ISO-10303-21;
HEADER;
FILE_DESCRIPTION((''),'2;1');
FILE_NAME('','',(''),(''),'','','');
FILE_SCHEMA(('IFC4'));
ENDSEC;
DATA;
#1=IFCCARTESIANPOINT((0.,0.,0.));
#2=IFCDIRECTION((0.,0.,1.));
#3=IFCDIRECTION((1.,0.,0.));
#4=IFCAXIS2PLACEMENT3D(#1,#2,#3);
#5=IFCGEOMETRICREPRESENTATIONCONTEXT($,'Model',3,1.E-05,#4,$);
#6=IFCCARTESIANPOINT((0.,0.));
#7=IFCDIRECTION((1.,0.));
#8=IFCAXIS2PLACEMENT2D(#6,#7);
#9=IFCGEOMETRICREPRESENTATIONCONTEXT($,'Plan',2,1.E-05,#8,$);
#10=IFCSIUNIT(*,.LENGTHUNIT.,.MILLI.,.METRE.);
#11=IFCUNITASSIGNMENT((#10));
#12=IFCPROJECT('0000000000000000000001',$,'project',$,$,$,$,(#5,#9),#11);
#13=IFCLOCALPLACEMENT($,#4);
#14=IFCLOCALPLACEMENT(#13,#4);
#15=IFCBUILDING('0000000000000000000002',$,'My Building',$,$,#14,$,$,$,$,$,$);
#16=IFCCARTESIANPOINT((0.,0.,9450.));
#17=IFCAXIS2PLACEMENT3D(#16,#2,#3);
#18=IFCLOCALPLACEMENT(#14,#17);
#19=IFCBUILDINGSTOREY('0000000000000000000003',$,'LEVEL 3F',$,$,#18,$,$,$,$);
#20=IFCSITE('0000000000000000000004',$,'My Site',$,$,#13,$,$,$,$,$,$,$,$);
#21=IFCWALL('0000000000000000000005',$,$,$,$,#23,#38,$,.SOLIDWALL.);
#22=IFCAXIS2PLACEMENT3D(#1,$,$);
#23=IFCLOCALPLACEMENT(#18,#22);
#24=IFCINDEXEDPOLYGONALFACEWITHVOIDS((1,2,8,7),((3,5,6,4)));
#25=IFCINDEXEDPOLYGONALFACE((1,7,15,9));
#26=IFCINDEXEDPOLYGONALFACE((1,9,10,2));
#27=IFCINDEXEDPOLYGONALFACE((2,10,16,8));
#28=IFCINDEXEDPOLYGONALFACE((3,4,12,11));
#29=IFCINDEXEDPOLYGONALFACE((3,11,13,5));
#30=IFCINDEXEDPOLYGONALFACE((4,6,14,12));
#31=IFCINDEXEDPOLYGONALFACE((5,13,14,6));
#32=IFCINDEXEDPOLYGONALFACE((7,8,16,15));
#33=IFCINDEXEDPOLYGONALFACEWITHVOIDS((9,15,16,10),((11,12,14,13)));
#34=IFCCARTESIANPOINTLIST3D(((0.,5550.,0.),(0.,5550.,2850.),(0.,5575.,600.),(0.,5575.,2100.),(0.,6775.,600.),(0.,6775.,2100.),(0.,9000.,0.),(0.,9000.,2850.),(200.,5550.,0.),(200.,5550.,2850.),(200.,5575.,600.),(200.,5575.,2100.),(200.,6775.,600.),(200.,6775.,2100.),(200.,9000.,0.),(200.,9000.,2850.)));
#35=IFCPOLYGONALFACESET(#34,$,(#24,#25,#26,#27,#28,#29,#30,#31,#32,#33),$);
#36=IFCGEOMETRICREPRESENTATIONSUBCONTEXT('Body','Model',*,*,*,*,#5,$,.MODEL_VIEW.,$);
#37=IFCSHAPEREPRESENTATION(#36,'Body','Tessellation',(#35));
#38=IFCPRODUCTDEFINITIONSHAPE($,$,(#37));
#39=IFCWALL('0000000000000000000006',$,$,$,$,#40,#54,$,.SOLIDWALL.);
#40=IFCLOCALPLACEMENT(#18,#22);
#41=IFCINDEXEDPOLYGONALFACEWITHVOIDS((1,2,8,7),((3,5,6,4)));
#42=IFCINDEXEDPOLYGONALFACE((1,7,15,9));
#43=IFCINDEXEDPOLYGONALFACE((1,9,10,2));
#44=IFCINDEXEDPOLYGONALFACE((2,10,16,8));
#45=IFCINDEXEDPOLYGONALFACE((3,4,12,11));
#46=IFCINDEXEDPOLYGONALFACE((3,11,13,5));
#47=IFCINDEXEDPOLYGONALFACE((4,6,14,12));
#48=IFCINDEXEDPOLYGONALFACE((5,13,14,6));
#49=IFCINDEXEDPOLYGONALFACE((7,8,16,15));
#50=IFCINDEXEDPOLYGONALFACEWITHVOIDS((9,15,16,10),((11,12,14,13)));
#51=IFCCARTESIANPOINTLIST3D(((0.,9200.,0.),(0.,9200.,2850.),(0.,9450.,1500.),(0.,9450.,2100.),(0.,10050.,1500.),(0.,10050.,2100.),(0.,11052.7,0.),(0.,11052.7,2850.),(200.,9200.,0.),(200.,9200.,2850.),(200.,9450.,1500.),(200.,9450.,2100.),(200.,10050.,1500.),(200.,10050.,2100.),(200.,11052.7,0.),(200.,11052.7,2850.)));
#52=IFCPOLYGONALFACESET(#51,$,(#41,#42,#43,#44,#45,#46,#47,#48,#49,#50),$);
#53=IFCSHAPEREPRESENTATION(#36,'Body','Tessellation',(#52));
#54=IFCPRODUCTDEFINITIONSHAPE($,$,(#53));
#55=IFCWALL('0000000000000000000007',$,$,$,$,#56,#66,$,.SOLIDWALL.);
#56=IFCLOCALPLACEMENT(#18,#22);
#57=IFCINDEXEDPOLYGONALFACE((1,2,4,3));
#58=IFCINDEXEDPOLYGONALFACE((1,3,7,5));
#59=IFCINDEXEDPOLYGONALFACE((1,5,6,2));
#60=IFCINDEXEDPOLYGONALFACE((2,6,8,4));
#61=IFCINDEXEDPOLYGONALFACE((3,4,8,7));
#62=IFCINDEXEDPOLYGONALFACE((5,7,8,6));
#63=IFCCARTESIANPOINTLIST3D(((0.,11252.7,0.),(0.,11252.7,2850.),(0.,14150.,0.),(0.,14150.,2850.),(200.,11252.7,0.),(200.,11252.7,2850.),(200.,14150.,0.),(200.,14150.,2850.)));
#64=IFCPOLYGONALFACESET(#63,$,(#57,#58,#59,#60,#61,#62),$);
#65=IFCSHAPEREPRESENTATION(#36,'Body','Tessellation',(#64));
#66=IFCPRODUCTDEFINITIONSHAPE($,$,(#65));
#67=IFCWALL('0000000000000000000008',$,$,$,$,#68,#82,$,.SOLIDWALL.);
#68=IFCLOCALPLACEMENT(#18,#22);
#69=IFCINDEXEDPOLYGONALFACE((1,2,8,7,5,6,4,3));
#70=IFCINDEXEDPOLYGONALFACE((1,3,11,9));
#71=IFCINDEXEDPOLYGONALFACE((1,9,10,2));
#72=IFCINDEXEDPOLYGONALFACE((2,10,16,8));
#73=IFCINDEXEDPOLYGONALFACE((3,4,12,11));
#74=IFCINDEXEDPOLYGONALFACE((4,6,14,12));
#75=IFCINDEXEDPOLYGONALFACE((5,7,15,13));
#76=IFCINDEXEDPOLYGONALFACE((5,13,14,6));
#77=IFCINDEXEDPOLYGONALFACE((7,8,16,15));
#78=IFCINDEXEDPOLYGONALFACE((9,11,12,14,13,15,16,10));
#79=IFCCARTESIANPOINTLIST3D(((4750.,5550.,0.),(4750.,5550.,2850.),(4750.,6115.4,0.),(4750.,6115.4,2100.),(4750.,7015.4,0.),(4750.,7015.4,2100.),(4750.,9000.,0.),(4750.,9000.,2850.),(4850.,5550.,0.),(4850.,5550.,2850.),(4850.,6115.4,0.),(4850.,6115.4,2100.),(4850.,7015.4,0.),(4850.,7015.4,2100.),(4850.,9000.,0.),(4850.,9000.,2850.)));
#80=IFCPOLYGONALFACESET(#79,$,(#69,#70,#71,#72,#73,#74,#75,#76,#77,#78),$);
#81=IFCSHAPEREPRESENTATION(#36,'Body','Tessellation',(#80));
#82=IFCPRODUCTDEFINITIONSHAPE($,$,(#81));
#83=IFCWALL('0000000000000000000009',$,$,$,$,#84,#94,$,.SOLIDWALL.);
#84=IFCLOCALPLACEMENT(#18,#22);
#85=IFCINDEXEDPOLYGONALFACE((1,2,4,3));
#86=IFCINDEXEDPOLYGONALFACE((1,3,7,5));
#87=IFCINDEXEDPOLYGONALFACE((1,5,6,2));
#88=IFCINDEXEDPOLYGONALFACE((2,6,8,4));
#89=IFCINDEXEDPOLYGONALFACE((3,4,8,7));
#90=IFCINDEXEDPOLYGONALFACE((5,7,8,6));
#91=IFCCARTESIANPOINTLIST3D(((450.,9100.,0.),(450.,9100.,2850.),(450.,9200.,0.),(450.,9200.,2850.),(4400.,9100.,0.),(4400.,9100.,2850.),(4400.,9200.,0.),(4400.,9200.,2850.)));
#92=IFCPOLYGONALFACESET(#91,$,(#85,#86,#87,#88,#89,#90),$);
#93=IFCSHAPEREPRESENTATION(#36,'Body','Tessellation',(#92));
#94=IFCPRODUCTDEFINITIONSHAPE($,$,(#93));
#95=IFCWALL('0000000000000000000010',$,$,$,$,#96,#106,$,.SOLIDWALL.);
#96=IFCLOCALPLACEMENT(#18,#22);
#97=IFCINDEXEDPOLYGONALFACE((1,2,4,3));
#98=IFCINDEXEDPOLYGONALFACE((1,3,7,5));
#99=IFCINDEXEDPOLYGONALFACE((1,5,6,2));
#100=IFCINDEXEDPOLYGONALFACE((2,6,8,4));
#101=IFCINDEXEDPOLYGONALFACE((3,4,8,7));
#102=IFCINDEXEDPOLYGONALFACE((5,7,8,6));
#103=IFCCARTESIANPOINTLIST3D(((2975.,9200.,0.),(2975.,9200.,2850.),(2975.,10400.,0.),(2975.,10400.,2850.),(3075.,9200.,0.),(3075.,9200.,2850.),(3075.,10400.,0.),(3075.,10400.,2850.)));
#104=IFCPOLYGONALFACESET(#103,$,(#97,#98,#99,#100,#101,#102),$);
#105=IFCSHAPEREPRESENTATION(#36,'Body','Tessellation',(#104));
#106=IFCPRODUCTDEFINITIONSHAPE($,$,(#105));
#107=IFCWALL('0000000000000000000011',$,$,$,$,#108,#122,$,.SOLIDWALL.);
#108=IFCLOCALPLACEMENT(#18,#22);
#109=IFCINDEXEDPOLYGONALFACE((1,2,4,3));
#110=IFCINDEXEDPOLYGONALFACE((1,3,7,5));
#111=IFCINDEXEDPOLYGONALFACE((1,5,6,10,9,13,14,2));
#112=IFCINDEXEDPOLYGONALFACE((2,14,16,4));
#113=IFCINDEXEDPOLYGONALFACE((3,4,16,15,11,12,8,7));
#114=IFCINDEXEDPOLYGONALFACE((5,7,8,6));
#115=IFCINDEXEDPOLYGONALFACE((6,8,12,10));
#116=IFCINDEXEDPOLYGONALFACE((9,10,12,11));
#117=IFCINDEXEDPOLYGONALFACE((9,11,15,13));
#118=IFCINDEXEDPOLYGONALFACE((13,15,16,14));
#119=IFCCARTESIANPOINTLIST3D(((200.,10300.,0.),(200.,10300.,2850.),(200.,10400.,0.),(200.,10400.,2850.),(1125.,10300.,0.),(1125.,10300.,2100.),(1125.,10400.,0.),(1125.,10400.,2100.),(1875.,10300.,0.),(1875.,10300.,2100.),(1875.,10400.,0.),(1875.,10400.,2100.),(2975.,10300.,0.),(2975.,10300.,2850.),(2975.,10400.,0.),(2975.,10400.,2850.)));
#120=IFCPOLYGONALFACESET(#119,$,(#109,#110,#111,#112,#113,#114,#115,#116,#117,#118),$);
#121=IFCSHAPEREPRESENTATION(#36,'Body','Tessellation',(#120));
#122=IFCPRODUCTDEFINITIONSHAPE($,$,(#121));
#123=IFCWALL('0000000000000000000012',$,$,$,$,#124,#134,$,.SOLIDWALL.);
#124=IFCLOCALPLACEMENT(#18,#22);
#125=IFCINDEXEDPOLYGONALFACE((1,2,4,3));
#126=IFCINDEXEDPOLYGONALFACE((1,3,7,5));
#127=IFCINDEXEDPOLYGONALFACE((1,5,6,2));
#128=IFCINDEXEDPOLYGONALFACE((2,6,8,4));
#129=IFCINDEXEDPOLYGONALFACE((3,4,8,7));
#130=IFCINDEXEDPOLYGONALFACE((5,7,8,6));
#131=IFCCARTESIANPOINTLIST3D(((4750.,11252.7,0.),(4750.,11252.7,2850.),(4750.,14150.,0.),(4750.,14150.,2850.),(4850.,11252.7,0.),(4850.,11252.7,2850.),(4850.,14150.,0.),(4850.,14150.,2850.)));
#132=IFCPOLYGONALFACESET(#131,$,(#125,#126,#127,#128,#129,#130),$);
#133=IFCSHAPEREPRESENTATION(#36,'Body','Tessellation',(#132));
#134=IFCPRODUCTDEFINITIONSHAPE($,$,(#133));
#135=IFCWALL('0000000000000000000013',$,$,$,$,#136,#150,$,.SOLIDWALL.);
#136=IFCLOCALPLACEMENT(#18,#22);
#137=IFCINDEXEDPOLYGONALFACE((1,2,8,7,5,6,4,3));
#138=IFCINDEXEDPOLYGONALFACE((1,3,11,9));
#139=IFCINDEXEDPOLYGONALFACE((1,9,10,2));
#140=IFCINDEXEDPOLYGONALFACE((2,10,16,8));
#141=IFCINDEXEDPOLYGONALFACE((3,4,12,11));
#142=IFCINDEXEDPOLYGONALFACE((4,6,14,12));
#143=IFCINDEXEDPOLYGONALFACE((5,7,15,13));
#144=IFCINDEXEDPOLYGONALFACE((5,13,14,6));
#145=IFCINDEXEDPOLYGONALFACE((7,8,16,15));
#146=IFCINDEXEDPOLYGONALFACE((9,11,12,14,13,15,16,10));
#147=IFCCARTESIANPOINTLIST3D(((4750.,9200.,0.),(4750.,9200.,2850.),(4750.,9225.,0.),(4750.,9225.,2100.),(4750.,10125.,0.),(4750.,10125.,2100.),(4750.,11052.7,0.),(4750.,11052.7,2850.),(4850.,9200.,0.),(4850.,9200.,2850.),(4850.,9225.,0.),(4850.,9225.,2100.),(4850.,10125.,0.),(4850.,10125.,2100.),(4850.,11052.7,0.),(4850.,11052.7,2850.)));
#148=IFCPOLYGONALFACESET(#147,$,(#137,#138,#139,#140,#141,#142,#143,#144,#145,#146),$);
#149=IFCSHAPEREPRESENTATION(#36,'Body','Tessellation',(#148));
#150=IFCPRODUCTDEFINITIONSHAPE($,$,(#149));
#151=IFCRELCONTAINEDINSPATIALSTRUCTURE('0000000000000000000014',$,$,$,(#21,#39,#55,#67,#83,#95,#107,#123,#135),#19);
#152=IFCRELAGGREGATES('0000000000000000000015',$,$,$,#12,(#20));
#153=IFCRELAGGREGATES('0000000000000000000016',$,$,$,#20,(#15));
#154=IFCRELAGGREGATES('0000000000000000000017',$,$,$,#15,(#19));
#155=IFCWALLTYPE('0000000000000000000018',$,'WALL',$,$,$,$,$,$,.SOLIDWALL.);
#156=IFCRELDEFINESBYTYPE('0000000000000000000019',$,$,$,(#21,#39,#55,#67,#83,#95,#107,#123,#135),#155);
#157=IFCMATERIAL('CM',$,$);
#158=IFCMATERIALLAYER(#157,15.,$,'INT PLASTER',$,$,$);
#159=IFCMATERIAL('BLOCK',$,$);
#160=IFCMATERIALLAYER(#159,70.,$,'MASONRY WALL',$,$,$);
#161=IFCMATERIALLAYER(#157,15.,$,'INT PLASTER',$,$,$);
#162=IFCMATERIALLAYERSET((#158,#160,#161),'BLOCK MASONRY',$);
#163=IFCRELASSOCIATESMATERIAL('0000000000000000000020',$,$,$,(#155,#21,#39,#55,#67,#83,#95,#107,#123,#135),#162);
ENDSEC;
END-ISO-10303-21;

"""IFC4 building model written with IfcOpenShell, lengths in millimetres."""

from ifc_helpers import new_model, si_unit, frame, origin_with_axes, origin_2d_with_axis, place, context, subcontext, project, spatial, indexed_curve, outline, extrude, material, layer, layer_set, layer_usage, type_object, element, save


model = new_model("IFC4")

# Units and contexts
model_context = context("Model", 3, precision=1e-05, world=origin_with_axes())
plan_context = context("Plan", 2, precision=1e-05, world=origin_2d_with_axis())
body_context = subcontext(model_context, "Body", "Model", "MODEL_VIEW")
ifc_project = project(units=[si_unit("LENGTHUNIT", "METRE", prefix="MILLI")], contexts=[model_context, plan_context])

# Site, building, storey
site_placement = place(None, origin_with_axes())
site = spatial("IfcSite", under=ifc_project, at=site_placement, Name="My Site")
building_placement = place(site_placement, origin_with_axes())
building = spatial("IfcBuilding", under=site, at=building_placement, Name="My Building")
storey_placement = place(building_placement, frame((0.0, 0.0, 9450.0), z_axis=(0.0, 0.0, 1.0), x_axis=(1.0, 0.0, 0.0)))
storey = spatial("IfcBuildingStorey", under=building, at=storey_placement, Name="LEVEL 3F")

# Shared definitions
ifc_material_1 = material(Name="CM")
ifc_layer_1 = layer(ifc_material_1, 15.0, Name="INT PLASTER")
ifc_material_2 = material(Name="BLOCK")
ifc_layer_2 = layer(ifc_material_2, 70.0, Name="MASONRY WALL")
ifc_layer_3 = layer(ifc_material_1, 15.0, Name="INT PLASTER")
ifc_layer_set = layer_set([ifc_layer_1, ifc_layer_2, ifc_layer_3], Name="BLOCK MASONRY")
wall_type = type_object("IfcWallType", Name="WALL", PredefinedType="SOLIDWALL", material=ifc_layer_set)

# Walls, openings
ifc_layer_usage_1 = layer_usage(ifc_layer_set, "AXIS2", "POSITIVE", 0.0)
wall_1_placement = place(storey_placement, frame((200.0, 5550.0, 0.0), z_axis=(0.0, 0.0, 1.0), x_axis=(0.0, 1.0, 0.0)))
wall_1 = element("IfcWall", 1, at=wall_1_placement, inside=storey, type_object=wall_type, material=ifc_layer_usage_1, PredefinedType="SOLIDWALL", context=body_context, shape_type="SweptSolid", body=[
    extrude(outline(indexed_curve([(0.0, 0.0), (0.0, 200.0), (3450.0, 200.0), (3450.0, 0.0), (0.0, 0.0)], self_intersect=False)), origin_with_axes(), (0.0, 0.0, 1.0), 2850.0),
])
opening_1_placement = place(wall_1_placement, frame((25.0, 0.0, 600.0), z_axis=(0.0, 0.0, 1.0), x_axis=(1.0, 0.0, 0.0)))
element("IfcOpeningElement", 2, at=opening_1_placement, cuts=wall_1, PredefinedType="OPENING", context=body_context, shape_type="SweptSolid", body=[
    extrude(outline(indexed_curve([(0.0, 0.0), (0.0, 400.0), (1200.0, 400.0), (1200.0, 0.0), (0.0, 0.0)], self_intersect=False)), frame((0.0, -100.0, 0.0), z_axis=(0.0, 0.0, 1.0), x_axis=(1.0, 0.0, 0.0)), (0.0, 0.0, 1.0), 1500.0),
])
ifc_layer_usage_2 = layer_usage(ifc_layer_set, "AXIS2", "POSITIVE", 0.0)
wall_2_placement = place(storey_placement, frame((200.0, 9200.0, 0.0), z_axis=(0.0, 0.0, 1.0), x_axis=(0.0, 1.0, 0.0)))
wall_2 = element("IfcWall", 3, at=wall_2_placement, inside=storey, type_object=wall_type, material=ifc_layer_usage_2, PredefinedType="SOLIDWALL", context=body_context, shape_type="SweptSolid", body=[
    extrude(outline(indexed_curve([(0.0, 0.0), (0.0, 200.0), (1852.7, 200.0), (1852.7, 0.0), (0.0, 0.0)], self_intersect=False)), origin_with_axes(), (0.0, 0.0, 1.0), 2850.0),
])
opening_2_placement = place(wall_2_placement, frame((250.0, 0.0, 1500.0), z_axis=(0.0, 0.0, 1.0), x_axis=(1.0, 0.0, 0.0)))
element("IfcOpeningElement", 4, at=opening_2_placement, cuts=wall_2, PredefinedType="OPENING", context=body_context, shape_type="SweptSolid", body=[
    extrude(outline(indexed_curve([(0.0, 0.0), (0.0, 400.0), (600.0, 400.0), (600.0, 0.0), (0.0, 0.0)], self_intersect=False)), frame((0.0, -100.0, 0.0), z_axis=(0.0, 0.0, 1.0), x_axis=(1.0, 0.0, 0.0)), (0.0, 0.0, 1.0), 600.0),
])

# Wall
ifc_layer_usage_3 = layer_usage(ifc_layer_set, "AXIS2", "POSITIVE", 0.0)
wall_3_placement = place(storey_placement, frame((200.0, 11252.7, 0.0), z_axis=(0.0, 0.0, 1.0), x_axis=(0.0, 1.0, 0.0)))
element("IfcWall", 5, at=wall_3_placement, inside=storey, type_object=wall_type, material=ifc_layer_usage_3, PredefinedType="SOLIDWALL", context=body_context, shape_type="SweptSolid", body=[
    extrude(outline(indexed_curve([(0.0, 0.0), (0.0, 200.0), (2897.3, 200.0), (2897.3, 0.0), (0.0, 0.0)], self_intersect=False)), origin_with_axes(), (0.0, 0.0, 1.0), 2850.0),
])

# Wall, opening
ifc_layer_usage_4 = layer_usage(ifc_layer_set, "AXIS2", "POSITIVE", 0.0)
wall_4_placement = place(storey_placement, frame((4850.0, 5550.0, 0.0), z_axis=(0.0, 0.0, 1.0), x_axis=(0.0, 1.0, 0.0)))
wall_4 = element("IfcWall", 6, at=wall_4_placement, inside=storey, type_object=wall_type, material=ifc_layer_usage_4, PredefinedType="SOLIDWALL", context=body_context, shape_type="SweptSolid", body=[
    extrude(outline(indexed_curve([(0.0, 0.0), (0.0, 100.0), (3450.0, 100.0), (3450.0, 0.0), (0.0, 0.0)], self_intersect=False)), origin_with_axes(), (0.0, 0.0, 1.0), 2850.0),
])
opening_3_placement = place(wall_4_placement, frame((565.4, 0.0, 0.0), z_axis=(0.0, 0.0, 1.0), x_axis=(1.0, 0.0, 0.0)))
element("IfcOpeningElement", 7, at=opening_3_placement, cuts=wall_4, PredefinedType="OPENING", context=body_context, shape_type="SweptSolid", body=[
    extrude(outline(indexed_curve([(0.0, 0.0), (0.0, 400.0), (900.0, 400.0), (900.0, 0.0), (0.0, 0.0)], self_intersect=False)), frame((0.0, -100.0, 0.0), z_axis=(0.0, 0.0, 1.0), x_axis=(1.0, 0.0, 0.0)), (0.0, 0.0, 1.0), 2100.0),
])

# Walls
ifc_layer_usage_5 = layer_usage(ifc_layer_set, "AXIS2", "POSITIVE", 0.0)
wall_5_placement = place(storey_placement, frame((450.0, 9200.0, 0.0), z_axis=(0.0, 0.0, 1.0), x_axis=(0.0, -1.0, 0.0)))
element("IfcWall", 8, at=wall_5_placement, inside=storey, type_object=wall_type, material=ifc_layer_usage_5, PredefinedType="SOLIDWALL", context=body_context, shape_type="SweptSolid", body=[
    extrude(outline(indexed_curve([(0.0, 0.0), (0.0, 3950.0), (100.0, 3950.0), (100.0, 0.0), (0.0, 0.0)], self_intersect=False)), origin_with_axes(), (0.0, 0.0, 1.0), 2850.0),
])
ifc_layer_usage_6 = layer_usage(ifc_layer_set, "AXIS2", "POSITIVE", 0.0)
wall_6_placement = place(storey_placement, frame((3075.0, 9200.0, 0.0), z_axis=(0.0, 0.0, 1.0), x_axis=(0.0, 1.0, 0.0)))
element("IfcWall", 9, at=wall_6_placement, inside=storey, type_object=wall_type, material=ifc_layer_usage_6, PredefinedType="SOLIDWALL", context=body_context, shape_type="SweptSolid", body=[
    extrude(outline(indexed_curve([(0.0, 0.0), (0.0, 100.0), (1200.0, 100.0), (1200.0, 0.0), (0.0, 0.0)], self_intersect=False)), origin_with_axes(), (0.0, 0.0, 1.0), 2850.0),
])

# Wall, opening
ifc_layer_usage_7 = layer_usage(ifc_layer_set, "AXIS2", "POSITIVE", 0.0)
wall_7_placement = place(storey_placement, frame((200.0, 10400.0, 0.0), z_axis=(0.0, 0.0, 1.0), x_axis=(0.0, -1.0, 0.0)))
wall_7 = element("IfcWall", 10, at=wall_7_placement, inside=storey, type_object=wall_type, material=ifc_layer_usage_7, PredefinedType="SOLIDWALL", context=body_context, shape_type="SweptSolid", body=[
    extrude(outline(indexed_curve([(0.0, 0.0), (0.0, 2775.0), (100.0, 2775.0), (100.0, 0.0), (0.0, 0.0)], self_intersect=False)), origin_with_axes(), (0.0, 0.0, 1.0), 2850.0),
])
opening_4_placement = place(wall_7_placement, frame((0.0, 1675.0, 0.0), z_axis=(0.0, 0.0, 1.0), x_axis=(0.0, -1.0, 0.0)))
element("IfcOpeningElement", 11, at=opening_4_placement, cuts=wall_7, PredefinedType="OPENING", context=body_context, shape_type="SweptSolid", body=[
    extrude(outline(indexed_curve([(0.0, 0.0), (0.0, 400.0), (750.0, 400.0), (750.0, 0.0), (0.0, 0.0)], self_intersect=False)), frame((0.0, -100.0, 0.0), z_axis=(0.0, 0.0, 1.0), x_axis=(1.0, 0.0, 0.0)), (0.0, 0.0, 1.0), 2100.0),
])

# Wall
ifc_layer_usage_8 = layer_usage(ifc_layer_set, "AXIS2", "POSITIVE", 0.0)
wall_8_placement = place(storey_placement, frame((4850.0, 11252.7, 0.0), z_axis=(0.0, 0.0, 1.0), x_axis=(0.0, 1.0, 0.0)))
element("IfcWall", 12, at=wall_8_placement, inside=storey, type_object=wall_type, material=ifc_layer_usage_8, PredefinedType="SOLIDWALL", context=body_context, shape_type="SweptSolid", body=[
    extrude(outline(indexed_curve([(0.0, 0.0), (0.0, 100.0), (2897.3, 100.0), (2897.3, 0.0), (0.0, 0.0)], self_intersect=False)), origin_with_axes(), (0.0, 0.0, 1.0), 2850.0),
])

# Wall, opening
ifc_layer_usage_9 = layer_usage(ifc_layer_set, "AXIS2", "POSITIVE", 0.0)
wall_9_placement = place(storey_placement, frame((4850.0, 9200.0, 0.0), z_axis=(0.0, 0.0, 1.0), x_axis=(0.0, 1.0, 0.0)))
wall_9 = element("IfcWall", 13, at=wall_9_placement, inside=storey, type_object=wall_type, material=ifc_layer_usage_9, PredefinedType="SOLIDWALL", context=body_context, shape_type="SweptSolid", body=[
    extrude(outline(indexed_curve([(0.0, 0.0), (0.0, 100.0), (1852.7, 100.0), (1852.7, 0.0), (0.0, 0.0)], self_intersect=False)), origin_with_axes(), (0.0, 0.0, 1.0), 2850.0),
])
opening_5_placement = place(wall_9_placement, frame((25.0, 0.0, 0.0), z_axis=(0.0, 0.0, 1.0), x_axis=(1.0, 0.0, 0.0)))
element("IfcOpeningElement", 14, at=opening_5_placement, cuts=wall_9, PredefinedType="OPENING", context=body_context, shape_type="SweptSolid", body=[
    extrude(outline(indexed_curve([(0.0, 0.0), (0.0, 400.0), (900.0, 400.0), (900.0, 0.0), (0.0, 0.0)], self_intersect=False)), frame((0.0, -100.0, 0.0), z_axis=(0.0, 0.0, 1.0), x_axis=(1.0, 0.0, 0.0)), (0.0, 0.0, 1.0), 2100.0),
])

save(model, "model.ifc")
